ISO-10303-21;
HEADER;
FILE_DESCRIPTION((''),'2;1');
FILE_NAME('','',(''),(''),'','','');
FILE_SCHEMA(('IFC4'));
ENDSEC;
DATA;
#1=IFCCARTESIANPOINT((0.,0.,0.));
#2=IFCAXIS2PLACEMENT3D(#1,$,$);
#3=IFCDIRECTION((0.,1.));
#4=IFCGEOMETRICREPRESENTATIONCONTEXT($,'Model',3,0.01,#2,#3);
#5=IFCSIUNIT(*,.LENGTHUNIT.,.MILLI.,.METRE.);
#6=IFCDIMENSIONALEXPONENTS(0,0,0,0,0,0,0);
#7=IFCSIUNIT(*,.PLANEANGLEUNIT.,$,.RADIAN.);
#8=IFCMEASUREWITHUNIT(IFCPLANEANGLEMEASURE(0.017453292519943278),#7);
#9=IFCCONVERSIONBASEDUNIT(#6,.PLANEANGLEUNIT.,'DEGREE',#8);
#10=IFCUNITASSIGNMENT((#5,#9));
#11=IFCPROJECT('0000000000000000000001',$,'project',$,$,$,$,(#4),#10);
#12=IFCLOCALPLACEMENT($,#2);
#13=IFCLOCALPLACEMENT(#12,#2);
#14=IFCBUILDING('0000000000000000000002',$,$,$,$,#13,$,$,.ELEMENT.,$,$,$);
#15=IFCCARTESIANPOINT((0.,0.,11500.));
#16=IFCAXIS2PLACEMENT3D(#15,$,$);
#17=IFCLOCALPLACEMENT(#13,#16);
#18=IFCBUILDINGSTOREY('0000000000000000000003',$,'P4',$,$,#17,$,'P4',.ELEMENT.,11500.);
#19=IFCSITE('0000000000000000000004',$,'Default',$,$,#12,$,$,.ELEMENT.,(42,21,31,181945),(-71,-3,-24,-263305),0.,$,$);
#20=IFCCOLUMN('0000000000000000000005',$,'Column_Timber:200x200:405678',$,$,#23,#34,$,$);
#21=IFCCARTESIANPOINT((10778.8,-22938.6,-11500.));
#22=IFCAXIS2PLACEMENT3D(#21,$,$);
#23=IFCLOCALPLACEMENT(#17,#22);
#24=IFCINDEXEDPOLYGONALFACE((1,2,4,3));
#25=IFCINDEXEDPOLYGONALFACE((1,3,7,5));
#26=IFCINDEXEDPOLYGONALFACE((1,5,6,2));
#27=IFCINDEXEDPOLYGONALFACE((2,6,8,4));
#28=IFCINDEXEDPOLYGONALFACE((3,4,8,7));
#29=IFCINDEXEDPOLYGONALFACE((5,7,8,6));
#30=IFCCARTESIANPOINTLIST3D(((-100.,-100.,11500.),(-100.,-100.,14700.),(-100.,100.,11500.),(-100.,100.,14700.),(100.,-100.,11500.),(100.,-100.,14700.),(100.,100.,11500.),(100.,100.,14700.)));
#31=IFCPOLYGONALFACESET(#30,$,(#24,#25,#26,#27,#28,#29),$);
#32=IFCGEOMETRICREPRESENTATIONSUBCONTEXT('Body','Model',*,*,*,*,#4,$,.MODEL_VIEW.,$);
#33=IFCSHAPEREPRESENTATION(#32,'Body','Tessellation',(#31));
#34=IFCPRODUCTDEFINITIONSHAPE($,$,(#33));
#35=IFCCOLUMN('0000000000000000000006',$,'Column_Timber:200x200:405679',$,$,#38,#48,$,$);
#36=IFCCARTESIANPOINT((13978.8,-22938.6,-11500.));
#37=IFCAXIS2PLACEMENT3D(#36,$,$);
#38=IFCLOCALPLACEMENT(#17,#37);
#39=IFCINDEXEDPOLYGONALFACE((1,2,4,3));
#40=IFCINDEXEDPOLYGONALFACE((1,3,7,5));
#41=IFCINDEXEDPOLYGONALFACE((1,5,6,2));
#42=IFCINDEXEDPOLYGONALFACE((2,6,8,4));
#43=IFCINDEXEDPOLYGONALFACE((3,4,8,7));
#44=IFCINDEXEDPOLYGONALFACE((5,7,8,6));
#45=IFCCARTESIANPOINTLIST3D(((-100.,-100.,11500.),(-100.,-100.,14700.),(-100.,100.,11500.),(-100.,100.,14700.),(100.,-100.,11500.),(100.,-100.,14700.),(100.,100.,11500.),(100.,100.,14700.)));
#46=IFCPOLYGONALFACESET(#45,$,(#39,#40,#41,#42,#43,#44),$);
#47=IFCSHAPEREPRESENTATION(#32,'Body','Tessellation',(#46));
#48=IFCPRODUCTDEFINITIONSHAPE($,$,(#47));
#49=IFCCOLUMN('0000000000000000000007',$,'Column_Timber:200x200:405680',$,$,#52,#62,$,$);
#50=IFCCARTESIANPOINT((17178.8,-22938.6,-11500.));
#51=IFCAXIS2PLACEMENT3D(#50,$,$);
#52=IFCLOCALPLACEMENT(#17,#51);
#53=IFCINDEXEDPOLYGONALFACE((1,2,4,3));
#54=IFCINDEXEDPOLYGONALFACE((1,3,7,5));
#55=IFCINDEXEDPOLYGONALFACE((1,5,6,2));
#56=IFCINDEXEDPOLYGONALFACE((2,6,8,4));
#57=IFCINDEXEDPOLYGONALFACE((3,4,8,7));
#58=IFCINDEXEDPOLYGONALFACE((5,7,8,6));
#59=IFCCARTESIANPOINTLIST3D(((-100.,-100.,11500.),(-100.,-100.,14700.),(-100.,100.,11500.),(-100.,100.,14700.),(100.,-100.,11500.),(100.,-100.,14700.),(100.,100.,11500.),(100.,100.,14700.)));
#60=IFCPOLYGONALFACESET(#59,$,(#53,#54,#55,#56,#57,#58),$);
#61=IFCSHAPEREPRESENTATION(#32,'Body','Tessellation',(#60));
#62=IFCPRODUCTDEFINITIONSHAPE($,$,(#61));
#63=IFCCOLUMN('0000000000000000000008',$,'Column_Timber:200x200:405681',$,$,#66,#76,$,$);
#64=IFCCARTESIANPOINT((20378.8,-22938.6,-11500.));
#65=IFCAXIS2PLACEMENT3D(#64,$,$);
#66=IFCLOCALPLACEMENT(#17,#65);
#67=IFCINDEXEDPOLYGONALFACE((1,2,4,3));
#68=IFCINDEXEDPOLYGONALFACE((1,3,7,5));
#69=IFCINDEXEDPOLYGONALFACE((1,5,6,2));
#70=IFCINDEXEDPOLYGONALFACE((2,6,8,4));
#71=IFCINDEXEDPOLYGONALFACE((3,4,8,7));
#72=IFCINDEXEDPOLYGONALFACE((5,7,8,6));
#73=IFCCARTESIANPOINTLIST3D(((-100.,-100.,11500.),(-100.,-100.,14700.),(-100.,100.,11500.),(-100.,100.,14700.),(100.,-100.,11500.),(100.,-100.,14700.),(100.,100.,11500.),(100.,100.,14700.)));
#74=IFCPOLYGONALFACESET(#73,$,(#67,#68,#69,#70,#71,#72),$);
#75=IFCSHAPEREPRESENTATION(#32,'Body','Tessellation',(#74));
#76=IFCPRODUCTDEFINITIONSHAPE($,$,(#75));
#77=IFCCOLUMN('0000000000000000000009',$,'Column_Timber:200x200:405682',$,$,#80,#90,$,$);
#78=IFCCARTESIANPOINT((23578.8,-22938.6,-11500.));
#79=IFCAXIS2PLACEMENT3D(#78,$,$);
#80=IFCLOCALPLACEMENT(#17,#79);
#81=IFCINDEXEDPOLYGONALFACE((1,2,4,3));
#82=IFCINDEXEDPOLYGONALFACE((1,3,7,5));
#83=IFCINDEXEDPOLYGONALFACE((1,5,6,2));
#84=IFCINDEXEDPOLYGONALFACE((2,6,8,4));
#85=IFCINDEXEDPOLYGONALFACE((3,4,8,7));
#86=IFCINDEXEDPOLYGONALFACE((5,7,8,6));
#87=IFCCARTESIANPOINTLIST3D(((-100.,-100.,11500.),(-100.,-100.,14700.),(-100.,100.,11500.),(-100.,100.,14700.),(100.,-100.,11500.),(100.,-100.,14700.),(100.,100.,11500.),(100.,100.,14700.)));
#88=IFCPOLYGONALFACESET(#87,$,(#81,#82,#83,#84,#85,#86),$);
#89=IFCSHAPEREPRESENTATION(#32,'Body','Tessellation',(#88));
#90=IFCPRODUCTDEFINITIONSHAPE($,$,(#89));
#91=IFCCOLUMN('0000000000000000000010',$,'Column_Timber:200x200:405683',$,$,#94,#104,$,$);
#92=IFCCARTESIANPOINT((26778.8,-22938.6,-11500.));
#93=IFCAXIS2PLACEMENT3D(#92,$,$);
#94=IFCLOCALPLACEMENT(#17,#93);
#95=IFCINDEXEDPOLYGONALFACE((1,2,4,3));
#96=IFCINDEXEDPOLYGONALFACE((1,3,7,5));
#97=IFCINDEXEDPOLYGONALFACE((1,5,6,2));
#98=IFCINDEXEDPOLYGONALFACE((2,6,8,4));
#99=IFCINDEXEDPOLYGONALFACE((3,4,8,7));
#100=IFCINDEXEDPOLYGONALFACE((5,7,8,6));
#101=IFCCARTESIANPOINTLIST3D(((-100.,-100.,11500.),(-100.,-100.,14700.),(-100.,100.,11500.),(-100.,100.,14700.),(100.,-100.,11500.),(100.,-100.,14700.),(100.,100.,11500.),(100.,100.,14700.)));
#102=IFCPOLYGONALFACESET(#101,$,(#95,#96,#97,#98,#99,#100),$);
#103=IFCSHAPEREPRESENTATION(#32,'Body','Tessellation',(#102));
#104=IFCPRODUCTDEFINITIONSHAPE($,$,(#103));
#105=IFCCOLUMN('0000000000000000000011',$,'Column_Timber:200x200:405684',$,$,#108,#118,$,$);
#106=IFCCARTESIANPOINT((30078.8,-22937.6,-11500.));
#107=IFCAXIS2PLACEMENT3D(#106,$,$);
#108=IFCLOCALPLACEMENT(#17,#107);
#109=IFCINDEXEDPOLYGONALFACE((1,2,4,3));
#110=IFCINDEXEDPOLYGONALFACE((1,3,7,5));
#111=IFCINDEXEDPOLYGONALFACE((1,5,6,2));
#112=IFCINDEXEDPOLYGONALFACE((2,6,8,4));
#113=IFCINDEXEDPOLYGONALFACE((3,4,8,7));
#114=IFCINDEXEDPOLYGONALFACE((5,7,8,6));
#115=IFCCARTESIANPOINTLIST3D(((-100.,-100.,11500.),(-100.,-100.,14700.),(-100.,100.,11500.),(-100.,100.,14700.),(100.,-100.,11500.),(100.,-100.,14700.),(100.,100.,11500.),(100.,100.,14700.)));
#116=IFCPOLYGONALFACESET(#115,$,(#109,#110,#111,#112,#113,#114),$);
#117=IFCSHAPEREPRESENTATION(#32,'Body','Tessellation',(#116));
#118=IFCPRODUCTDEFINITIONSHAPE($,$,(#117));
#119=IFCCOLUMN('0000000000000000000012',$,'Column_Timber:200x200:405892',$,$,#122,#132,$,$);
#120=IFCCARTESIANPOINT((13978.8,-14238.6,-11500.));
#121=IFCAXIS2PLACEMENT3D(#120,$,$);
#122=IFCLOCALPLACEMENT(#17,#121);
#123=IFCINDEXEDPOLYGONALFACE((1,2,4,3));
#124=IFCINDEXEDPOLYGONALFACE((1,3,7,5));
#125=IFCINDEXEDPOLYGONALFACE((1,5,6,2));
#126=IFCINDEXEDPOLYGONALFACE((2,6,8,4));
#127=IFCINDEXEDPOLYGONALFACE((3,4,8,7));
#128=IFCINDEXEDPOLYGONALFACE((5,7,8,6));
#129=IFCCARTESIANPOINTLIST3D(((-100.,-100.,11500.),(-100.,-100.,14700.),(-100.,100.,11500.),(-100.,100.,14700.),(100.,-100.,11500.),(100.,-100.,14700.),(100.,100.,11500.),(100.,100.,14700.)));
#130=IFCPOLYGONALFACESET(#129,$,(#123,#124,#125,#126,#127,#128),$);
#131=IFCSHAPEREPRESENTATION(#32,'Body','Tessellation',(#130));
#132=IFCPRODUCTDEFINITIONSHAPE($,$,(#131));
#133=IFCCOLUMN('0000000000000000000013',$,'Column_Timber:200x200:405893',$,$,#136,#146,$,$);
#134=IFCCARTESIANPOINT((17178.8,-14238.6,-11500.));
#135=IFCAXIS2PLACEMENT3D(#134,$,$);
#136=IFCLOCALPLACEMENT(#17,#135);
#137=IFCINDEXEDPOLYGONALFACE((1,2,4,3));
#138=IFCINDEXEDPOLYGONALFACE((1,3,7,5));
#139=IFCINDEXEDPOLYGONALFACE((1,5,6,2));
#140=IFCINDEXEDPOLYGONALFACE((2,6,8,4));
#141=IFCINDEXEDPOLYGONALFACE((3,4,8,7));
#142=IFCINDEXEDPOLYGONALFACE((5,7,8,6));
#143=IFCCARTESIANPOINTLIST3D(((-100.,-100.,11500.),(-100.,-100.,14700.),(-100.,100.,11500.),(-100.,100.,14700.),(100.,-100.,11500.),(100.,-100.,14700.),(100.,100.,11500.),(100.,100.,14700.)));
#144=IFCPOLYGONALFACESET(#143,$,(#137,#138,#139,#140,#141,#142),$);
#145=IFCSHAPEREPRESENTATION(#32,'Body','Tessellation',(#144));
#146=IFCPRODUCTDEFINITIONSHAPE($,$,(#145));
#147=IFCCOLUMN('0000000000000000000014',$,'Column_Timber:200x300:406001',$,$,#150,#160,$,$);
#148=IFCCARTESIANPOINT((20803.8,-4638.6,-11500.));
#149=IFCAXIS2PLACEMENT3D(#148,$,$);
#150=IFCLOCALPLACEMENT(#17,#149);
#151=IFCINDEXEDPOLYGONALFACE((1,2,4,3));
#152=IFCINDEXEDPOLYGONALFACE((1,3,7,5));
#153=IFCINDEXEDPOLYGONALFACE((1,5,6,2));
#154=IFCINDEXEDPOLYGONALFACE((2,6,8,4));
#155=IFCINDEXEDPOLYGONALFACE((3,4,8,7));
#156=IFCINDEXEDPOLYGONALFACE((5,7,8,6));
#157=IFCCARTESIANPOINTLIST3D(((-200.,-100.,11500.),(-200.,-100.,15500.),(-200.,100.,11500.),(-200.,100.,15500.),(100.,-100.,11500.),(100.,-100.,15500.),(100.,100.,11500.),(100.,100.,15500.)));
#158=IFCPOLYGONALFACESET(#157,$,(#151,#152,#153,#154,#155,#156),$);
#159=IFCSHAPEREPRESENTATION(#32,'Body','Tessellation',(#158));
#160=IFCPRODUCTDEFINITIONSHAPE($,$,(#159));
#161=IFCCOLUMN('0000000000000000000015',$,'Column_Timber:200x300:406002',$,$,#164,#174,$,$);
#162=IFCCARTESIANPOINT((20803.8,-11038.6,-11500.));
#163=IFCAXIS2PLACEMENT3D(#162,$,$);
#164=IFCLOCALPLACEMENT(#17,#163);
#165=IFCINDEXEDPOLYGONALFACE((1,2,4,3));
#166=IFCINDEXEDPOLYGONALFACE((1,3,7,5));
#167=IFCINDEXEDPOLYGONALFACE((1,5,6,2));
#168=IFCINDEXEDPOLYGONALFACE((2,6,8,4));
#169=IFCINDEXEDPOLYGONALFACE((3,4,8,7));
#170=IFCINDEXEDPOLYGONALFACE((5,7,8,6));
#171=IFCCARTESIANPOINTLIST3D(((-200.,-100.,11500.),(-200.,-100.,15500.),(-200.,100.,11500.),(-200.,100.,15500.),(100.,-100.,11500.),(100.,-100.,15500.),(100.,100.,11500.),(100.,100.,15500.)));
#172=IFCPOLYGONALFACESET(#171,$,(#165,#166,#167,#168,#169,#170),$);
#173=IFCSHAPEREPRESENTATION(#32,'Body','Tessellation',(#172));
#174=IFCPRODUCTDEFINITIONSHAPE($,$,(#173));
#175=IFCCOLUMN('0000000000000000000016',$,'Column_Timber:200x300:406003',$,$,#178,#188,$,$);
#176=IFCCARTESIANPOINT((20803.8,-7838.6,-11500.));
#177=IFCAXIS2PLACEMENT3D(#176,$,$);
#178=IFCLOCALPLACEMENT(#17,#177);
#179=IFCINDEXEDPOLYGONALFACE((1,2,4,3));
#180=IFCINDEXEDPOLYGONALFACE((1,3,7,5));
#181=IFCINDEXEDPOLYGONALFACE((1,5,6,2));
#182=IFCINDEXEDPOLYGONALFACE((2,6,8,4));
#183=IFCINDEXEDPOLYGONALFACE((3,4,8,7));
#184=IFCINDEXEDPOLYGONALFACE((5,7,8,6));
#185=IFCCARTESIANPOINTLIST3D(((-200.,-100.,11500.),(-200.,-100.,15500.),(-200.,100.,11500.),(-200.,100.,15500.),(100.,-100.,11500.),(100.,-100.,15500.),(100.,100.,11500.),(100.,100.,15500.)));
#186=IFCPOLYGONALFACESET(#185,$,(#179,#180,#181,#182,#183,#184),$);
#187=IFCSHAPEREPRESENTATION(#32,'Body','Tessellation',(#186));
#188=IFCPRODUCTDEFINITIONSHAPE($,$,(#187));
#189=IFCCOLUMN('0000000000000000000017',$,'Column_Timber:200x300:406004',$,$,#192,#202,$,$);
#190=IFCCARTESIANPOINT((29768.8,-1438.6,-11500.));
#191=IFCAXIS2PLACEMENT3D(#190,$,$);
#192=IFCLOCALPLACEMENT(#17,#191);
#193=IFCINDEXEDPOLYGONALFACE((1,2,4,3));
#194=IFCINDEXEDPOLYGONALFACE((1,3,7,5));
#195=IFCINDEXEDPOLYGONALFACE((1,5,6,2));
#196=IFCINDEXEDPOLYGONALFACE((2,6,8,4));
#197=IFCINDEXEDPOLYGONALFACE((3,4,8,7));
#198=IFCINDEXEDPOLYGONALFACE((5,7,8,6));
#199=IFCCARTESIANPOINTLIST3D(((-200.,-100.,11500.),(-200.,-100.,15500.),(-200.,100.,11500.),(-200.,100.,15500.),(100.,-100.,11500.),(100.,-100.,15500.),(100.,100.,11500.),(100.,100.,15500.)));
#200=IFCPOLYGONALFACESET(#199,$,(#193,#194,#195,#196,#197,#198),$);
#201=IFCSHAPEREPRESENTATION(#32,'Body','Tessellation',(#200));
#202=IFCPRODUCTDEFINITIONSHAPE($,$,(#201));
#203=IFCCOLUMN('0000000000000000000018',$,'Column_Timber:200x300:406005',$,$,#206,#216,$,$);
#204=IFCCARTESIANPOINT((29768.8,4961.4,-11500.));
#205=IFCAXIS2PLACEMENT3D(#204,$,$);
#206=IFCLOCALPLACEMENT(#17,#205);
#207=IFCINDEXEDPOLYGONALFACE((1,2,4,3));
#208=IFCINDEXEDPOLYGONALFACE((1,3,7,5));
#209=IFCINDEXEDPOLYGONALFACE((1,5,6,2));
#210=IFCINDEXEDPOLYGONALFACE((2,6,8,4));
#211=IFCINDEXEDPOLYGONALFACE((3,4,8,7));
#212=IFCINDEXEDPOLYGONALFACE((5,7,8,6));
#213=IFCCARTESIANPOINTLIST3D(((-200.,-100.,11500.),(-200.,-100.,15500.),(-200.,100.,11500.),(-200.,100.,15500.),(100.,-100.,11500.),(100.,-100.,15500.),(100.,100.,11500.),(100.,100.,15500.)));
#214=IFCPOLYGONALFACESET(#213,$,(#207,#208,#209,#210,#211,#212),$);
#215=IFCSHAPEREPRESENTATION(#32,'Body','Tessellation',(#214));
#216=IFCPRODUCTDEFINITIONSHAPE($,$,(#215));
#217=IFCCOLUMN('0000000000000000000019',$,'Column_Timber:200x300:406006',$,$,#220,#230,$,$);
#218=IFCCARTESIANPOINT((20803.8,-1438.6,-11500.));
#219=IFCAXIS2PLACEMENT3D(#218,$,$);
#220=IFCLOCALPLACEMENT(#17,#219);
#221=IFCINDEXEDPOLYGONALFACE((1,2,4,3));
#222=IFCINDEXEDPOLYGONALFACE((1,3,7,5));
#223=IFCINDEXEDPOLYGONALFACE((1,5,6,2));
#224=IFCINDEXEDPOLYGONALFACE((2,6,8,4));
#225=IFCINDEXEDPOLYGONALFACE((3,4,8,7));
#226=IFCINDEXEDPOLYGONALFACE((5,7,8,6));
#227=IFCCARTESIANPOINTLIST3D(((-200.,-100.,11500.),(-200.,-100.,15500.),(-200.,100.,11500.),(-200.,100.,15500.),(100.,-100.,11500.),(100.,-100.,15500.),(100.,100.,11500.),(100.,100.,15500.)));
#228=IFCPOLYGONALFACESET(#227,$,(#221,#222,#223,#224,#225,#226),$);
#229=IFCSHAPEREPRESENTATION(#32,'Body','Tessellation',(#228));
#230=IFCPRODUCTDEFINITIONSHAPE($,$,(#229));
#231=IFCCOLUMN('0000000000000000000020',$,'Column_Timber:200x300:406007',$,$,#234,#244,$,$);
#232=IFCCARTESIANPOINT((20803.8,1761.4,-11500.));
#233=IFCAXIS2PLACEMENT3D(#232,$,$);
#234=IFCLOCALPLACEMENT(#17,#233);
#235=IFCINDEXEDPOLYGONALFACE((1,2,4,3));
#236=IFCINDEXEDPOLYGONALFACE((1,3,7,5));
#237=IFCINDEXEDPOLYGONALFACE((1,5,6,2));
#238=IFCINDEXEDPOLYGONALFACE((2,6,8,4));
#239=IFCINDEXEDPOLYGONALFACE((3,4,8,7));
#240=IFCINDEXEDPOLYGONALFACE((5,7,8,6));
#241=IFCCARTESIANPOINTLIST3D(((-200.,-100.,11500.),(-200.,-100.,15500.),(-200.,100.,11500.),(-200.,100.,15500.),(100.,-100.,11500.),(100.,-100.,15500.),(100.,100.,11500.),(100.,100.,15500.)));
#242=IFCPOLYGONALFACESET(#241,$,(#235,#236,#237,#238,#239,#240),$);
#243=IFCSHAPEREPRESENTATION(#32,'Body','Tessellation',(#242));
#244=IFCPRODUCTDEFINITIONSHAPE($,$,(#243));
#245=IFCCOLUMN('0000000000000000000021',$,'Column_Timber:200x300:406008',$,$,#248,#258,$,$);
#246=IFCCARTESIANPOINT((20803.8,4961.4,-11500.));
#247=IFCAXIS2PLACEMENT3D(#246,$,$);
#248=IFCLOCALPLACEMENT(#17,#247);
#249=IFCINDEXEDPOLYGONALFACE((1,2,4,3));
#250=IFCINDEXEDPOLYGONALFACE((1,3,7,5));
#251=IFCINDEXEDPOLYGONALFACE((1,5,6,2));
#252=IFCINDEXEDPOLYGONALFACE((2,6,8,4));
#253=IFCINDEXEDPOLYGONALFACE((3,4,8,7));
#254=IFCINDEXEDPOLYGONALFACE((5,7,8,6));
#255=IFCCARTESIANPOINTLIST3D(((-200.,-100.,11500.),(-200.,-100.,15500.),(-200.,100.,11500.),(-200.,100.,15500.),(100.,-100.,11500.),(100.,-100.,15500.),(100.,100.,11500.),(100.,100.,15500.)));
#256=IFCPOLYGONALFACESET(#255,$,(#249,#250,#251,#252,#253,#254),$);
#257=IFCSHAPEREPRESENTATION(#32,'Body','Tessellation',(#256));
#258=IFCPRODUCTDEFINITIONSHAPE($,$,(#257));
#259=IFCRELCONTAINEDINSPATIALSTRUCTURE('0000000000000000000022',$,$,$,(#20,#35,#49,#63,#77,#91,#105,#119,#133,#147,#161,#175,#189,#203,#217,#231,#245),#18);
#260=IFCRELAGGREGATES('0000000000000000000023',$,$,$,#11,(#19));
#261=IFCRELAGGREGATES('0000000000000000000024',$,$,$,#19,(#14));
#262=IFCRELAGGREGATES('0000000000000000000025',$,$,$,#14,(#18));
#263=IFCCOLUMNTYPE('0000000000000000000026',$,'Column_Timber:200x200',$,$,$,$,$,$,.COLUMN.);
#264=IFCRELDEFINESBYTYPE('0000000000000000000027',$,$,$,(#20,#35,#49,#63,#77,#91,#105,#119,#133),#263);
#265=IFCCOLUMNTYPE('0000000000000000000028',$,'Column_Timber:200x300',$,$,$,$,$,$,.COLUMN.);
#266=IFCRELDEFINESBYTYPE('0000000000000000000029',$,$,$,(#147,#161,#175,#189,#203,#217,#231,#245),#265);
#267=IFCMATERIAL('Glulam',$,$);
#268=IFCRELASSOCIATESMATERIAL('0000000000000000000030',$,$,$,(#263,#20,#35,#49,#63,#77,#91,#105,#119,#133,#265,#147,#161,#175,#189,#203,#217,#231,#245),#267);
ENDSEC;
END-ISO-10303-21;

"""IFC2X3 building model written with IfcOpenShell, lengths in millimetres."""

from ifc_helpers import new_model, entity, si_unit, converted_unit, direction, frame, frame_2d, origin, origin_2d_with_axis, place, context, subcontext, project, spatial, rectangle, extrude, source, transform, mapped, material, type_object, type_shapes, element, save


model = new_model("IFC2X3")

# Units and contexts
model_context = context("Model", 3, precision=0.01, world=origin(), true_north=direction((0.0, 1.0)))
body_context = subcontext(model_context, "Body", "Model", "MODEL_VIEW")
ifc_project = project(units=[si_unit("LENGTHUNIT", "METRE", prefix="MILLI"), converted_unit("PLANEANGLEUNIT", "DEGREE", entity("IfcPlaneAngleMeasure", 0.017453292519943278), si_unit("PLANEANGLEUNIT", "RADIAN"), dimensions=[0, 0, 0, 0, 0, 0, 0])], contexts=[model_context])

# Site, building, storey
site_placement = place(None, origin())
site = spatial("IfcSite", under=ifc_project, at=site_placement, Name="Default", CompositionType="ELEMENT", RefLatitude=(42, 21, 31, 181945), RefLongitude=(-71, -3, -24, -263305), RefElevation=0.0)
building_placement = place(site_placement, origin())
building = spatial("IfcBuilding", under=site, at=building_placement, CompositionType="ELEMENT")
storey_placement = place(building_placement, frame((0.0, 0.0, 11500.0)))
storey = spatial("IfcBuildingStorey", under=building, at=storey_placement, Name="P4", LongName="P4", CompositionType="ELEMENT", Elevation=11500.0)

# Columns
ifc_material = material(Name="Glulam")
column_type_1 = type_object("IfcColumnType", Name="Column_Timber:200x200", PredefinedType="COLUMN", material=ifc_material)
shared_shape_1 = source(origin(), body_context, "Body", "SweptSolid", [
    extrude(rectangle(XDim=200.0, YDim=200.0, at=frame_2d((0.0, 0.0), x_axis=(1.0, 0.0))), frame((0.0, 0.0, 11500.0), z_axis=(0.0, 0.0, 1.0), x_axis=(-1.0, 0.0, 0.0)), (0.0, 0.0, 1.0), 3200.0),
])
type_shapes(column_type_1, [shared_shape_1])
for number, where, name in (
    (1, (10778.8, -22938.6, -11500.0), "Column_Timber:200x200:405678"),
    (2, (13978.8, -22938.6, -11500.0), "Column_Timber:200x200:405679"),
    (3, (17178.8, -22938.6, -11500.0), "Column_Timber:200x200:405680"),
    (4, (20378.8, -22938.6, -11500.0), "Column_Timber:200x200:405681"),
    (5, (23578.8, -22938.6, -11500.0), "Column_Timber:200x200:405682"),
    (6, (26778.8, -22938.6, -11500.0), "Column_Timber:200x200:405683"),
    (7, (30078.8, -22937.6, -11500.0), "Column_Timber:200x200:405684"),
    (8, (13978.8, -14238.6, -11500.0), "Column_Timber:200x200:405892"),
    (9, (17178.8, -14238.6, -11500.0), "Column_Timber:200x200:405893"),
):
    element("IfcColumn", number, at=place(storey_placement, frame(where)), inside=storey, type_object=column_type_1, material=ifc_material, Name=name, context=body_context, shape_type="MappedRepresentation", body=[
        mapped(shared_shape_1, transform((0.0, 0.0, 0.0), scale=1.0)),
    ])
column_type_2 = type_object("IfcColumnType", Name="Column_Timber:200x300", PredefinedType="COLUMN", material=ifc_material)
shared_shape_2 = source(origin(), body_context, "Body", "SweptSolid", [
    extrude(rectangle(XDim=300.0, YDim=200.0, at=origin_2d_with_axis()), frame((-50.0, 0.0, 11500.0), z_axis=(0.0, 0.0, 1.0), x_axis=(-1.0, 0.0, 0.0)), (0.0, 0.0, 1.0), 4000.0),
])
type_shapes(column_type_2, [shared_shape_2])
for number, where, name in (
    (10, (20803.8, -4638.6, -11500.0), "Column_Timber:200x300:406001"),
    (11, (20803.8, -11038.6, -11500.0), "Column_Timber:200x300:406002"),
    (12, (20803.8, -7838.6, -11500.0), "Column_Timber:200x300:406003"),
    (13, (29768.8, -1438.6, -11500.0), "Column_Timber:200x300:406004"),
    (14, (29768.8, 4961.4, -11500.0), "Column_Timber:200x300:406005"),
    (15, (20803.8, -1438.6, -11500.0), "Column_Timber:200x300:406006"),
    (16, (20803.8, 1761.4, -11500.0), "Column_Timber:200x300:406007"),
    (17, (20803.8, 4961.4, -11500.0), "Column_Timber:200x300:406008"),
):
    element("IfcColumn", number, at=place(storey_placement, frame(where)), inside=storey, type_object=column_type_2, material=ifc_material, Name=name, context=body_context, shape_type="MappedRepresentation", body=[
        mapped(shared_shape_2, transform((0.0, 0.0, 0.0), scale=1.0)),
    ])

save(model, "model.ifc")
